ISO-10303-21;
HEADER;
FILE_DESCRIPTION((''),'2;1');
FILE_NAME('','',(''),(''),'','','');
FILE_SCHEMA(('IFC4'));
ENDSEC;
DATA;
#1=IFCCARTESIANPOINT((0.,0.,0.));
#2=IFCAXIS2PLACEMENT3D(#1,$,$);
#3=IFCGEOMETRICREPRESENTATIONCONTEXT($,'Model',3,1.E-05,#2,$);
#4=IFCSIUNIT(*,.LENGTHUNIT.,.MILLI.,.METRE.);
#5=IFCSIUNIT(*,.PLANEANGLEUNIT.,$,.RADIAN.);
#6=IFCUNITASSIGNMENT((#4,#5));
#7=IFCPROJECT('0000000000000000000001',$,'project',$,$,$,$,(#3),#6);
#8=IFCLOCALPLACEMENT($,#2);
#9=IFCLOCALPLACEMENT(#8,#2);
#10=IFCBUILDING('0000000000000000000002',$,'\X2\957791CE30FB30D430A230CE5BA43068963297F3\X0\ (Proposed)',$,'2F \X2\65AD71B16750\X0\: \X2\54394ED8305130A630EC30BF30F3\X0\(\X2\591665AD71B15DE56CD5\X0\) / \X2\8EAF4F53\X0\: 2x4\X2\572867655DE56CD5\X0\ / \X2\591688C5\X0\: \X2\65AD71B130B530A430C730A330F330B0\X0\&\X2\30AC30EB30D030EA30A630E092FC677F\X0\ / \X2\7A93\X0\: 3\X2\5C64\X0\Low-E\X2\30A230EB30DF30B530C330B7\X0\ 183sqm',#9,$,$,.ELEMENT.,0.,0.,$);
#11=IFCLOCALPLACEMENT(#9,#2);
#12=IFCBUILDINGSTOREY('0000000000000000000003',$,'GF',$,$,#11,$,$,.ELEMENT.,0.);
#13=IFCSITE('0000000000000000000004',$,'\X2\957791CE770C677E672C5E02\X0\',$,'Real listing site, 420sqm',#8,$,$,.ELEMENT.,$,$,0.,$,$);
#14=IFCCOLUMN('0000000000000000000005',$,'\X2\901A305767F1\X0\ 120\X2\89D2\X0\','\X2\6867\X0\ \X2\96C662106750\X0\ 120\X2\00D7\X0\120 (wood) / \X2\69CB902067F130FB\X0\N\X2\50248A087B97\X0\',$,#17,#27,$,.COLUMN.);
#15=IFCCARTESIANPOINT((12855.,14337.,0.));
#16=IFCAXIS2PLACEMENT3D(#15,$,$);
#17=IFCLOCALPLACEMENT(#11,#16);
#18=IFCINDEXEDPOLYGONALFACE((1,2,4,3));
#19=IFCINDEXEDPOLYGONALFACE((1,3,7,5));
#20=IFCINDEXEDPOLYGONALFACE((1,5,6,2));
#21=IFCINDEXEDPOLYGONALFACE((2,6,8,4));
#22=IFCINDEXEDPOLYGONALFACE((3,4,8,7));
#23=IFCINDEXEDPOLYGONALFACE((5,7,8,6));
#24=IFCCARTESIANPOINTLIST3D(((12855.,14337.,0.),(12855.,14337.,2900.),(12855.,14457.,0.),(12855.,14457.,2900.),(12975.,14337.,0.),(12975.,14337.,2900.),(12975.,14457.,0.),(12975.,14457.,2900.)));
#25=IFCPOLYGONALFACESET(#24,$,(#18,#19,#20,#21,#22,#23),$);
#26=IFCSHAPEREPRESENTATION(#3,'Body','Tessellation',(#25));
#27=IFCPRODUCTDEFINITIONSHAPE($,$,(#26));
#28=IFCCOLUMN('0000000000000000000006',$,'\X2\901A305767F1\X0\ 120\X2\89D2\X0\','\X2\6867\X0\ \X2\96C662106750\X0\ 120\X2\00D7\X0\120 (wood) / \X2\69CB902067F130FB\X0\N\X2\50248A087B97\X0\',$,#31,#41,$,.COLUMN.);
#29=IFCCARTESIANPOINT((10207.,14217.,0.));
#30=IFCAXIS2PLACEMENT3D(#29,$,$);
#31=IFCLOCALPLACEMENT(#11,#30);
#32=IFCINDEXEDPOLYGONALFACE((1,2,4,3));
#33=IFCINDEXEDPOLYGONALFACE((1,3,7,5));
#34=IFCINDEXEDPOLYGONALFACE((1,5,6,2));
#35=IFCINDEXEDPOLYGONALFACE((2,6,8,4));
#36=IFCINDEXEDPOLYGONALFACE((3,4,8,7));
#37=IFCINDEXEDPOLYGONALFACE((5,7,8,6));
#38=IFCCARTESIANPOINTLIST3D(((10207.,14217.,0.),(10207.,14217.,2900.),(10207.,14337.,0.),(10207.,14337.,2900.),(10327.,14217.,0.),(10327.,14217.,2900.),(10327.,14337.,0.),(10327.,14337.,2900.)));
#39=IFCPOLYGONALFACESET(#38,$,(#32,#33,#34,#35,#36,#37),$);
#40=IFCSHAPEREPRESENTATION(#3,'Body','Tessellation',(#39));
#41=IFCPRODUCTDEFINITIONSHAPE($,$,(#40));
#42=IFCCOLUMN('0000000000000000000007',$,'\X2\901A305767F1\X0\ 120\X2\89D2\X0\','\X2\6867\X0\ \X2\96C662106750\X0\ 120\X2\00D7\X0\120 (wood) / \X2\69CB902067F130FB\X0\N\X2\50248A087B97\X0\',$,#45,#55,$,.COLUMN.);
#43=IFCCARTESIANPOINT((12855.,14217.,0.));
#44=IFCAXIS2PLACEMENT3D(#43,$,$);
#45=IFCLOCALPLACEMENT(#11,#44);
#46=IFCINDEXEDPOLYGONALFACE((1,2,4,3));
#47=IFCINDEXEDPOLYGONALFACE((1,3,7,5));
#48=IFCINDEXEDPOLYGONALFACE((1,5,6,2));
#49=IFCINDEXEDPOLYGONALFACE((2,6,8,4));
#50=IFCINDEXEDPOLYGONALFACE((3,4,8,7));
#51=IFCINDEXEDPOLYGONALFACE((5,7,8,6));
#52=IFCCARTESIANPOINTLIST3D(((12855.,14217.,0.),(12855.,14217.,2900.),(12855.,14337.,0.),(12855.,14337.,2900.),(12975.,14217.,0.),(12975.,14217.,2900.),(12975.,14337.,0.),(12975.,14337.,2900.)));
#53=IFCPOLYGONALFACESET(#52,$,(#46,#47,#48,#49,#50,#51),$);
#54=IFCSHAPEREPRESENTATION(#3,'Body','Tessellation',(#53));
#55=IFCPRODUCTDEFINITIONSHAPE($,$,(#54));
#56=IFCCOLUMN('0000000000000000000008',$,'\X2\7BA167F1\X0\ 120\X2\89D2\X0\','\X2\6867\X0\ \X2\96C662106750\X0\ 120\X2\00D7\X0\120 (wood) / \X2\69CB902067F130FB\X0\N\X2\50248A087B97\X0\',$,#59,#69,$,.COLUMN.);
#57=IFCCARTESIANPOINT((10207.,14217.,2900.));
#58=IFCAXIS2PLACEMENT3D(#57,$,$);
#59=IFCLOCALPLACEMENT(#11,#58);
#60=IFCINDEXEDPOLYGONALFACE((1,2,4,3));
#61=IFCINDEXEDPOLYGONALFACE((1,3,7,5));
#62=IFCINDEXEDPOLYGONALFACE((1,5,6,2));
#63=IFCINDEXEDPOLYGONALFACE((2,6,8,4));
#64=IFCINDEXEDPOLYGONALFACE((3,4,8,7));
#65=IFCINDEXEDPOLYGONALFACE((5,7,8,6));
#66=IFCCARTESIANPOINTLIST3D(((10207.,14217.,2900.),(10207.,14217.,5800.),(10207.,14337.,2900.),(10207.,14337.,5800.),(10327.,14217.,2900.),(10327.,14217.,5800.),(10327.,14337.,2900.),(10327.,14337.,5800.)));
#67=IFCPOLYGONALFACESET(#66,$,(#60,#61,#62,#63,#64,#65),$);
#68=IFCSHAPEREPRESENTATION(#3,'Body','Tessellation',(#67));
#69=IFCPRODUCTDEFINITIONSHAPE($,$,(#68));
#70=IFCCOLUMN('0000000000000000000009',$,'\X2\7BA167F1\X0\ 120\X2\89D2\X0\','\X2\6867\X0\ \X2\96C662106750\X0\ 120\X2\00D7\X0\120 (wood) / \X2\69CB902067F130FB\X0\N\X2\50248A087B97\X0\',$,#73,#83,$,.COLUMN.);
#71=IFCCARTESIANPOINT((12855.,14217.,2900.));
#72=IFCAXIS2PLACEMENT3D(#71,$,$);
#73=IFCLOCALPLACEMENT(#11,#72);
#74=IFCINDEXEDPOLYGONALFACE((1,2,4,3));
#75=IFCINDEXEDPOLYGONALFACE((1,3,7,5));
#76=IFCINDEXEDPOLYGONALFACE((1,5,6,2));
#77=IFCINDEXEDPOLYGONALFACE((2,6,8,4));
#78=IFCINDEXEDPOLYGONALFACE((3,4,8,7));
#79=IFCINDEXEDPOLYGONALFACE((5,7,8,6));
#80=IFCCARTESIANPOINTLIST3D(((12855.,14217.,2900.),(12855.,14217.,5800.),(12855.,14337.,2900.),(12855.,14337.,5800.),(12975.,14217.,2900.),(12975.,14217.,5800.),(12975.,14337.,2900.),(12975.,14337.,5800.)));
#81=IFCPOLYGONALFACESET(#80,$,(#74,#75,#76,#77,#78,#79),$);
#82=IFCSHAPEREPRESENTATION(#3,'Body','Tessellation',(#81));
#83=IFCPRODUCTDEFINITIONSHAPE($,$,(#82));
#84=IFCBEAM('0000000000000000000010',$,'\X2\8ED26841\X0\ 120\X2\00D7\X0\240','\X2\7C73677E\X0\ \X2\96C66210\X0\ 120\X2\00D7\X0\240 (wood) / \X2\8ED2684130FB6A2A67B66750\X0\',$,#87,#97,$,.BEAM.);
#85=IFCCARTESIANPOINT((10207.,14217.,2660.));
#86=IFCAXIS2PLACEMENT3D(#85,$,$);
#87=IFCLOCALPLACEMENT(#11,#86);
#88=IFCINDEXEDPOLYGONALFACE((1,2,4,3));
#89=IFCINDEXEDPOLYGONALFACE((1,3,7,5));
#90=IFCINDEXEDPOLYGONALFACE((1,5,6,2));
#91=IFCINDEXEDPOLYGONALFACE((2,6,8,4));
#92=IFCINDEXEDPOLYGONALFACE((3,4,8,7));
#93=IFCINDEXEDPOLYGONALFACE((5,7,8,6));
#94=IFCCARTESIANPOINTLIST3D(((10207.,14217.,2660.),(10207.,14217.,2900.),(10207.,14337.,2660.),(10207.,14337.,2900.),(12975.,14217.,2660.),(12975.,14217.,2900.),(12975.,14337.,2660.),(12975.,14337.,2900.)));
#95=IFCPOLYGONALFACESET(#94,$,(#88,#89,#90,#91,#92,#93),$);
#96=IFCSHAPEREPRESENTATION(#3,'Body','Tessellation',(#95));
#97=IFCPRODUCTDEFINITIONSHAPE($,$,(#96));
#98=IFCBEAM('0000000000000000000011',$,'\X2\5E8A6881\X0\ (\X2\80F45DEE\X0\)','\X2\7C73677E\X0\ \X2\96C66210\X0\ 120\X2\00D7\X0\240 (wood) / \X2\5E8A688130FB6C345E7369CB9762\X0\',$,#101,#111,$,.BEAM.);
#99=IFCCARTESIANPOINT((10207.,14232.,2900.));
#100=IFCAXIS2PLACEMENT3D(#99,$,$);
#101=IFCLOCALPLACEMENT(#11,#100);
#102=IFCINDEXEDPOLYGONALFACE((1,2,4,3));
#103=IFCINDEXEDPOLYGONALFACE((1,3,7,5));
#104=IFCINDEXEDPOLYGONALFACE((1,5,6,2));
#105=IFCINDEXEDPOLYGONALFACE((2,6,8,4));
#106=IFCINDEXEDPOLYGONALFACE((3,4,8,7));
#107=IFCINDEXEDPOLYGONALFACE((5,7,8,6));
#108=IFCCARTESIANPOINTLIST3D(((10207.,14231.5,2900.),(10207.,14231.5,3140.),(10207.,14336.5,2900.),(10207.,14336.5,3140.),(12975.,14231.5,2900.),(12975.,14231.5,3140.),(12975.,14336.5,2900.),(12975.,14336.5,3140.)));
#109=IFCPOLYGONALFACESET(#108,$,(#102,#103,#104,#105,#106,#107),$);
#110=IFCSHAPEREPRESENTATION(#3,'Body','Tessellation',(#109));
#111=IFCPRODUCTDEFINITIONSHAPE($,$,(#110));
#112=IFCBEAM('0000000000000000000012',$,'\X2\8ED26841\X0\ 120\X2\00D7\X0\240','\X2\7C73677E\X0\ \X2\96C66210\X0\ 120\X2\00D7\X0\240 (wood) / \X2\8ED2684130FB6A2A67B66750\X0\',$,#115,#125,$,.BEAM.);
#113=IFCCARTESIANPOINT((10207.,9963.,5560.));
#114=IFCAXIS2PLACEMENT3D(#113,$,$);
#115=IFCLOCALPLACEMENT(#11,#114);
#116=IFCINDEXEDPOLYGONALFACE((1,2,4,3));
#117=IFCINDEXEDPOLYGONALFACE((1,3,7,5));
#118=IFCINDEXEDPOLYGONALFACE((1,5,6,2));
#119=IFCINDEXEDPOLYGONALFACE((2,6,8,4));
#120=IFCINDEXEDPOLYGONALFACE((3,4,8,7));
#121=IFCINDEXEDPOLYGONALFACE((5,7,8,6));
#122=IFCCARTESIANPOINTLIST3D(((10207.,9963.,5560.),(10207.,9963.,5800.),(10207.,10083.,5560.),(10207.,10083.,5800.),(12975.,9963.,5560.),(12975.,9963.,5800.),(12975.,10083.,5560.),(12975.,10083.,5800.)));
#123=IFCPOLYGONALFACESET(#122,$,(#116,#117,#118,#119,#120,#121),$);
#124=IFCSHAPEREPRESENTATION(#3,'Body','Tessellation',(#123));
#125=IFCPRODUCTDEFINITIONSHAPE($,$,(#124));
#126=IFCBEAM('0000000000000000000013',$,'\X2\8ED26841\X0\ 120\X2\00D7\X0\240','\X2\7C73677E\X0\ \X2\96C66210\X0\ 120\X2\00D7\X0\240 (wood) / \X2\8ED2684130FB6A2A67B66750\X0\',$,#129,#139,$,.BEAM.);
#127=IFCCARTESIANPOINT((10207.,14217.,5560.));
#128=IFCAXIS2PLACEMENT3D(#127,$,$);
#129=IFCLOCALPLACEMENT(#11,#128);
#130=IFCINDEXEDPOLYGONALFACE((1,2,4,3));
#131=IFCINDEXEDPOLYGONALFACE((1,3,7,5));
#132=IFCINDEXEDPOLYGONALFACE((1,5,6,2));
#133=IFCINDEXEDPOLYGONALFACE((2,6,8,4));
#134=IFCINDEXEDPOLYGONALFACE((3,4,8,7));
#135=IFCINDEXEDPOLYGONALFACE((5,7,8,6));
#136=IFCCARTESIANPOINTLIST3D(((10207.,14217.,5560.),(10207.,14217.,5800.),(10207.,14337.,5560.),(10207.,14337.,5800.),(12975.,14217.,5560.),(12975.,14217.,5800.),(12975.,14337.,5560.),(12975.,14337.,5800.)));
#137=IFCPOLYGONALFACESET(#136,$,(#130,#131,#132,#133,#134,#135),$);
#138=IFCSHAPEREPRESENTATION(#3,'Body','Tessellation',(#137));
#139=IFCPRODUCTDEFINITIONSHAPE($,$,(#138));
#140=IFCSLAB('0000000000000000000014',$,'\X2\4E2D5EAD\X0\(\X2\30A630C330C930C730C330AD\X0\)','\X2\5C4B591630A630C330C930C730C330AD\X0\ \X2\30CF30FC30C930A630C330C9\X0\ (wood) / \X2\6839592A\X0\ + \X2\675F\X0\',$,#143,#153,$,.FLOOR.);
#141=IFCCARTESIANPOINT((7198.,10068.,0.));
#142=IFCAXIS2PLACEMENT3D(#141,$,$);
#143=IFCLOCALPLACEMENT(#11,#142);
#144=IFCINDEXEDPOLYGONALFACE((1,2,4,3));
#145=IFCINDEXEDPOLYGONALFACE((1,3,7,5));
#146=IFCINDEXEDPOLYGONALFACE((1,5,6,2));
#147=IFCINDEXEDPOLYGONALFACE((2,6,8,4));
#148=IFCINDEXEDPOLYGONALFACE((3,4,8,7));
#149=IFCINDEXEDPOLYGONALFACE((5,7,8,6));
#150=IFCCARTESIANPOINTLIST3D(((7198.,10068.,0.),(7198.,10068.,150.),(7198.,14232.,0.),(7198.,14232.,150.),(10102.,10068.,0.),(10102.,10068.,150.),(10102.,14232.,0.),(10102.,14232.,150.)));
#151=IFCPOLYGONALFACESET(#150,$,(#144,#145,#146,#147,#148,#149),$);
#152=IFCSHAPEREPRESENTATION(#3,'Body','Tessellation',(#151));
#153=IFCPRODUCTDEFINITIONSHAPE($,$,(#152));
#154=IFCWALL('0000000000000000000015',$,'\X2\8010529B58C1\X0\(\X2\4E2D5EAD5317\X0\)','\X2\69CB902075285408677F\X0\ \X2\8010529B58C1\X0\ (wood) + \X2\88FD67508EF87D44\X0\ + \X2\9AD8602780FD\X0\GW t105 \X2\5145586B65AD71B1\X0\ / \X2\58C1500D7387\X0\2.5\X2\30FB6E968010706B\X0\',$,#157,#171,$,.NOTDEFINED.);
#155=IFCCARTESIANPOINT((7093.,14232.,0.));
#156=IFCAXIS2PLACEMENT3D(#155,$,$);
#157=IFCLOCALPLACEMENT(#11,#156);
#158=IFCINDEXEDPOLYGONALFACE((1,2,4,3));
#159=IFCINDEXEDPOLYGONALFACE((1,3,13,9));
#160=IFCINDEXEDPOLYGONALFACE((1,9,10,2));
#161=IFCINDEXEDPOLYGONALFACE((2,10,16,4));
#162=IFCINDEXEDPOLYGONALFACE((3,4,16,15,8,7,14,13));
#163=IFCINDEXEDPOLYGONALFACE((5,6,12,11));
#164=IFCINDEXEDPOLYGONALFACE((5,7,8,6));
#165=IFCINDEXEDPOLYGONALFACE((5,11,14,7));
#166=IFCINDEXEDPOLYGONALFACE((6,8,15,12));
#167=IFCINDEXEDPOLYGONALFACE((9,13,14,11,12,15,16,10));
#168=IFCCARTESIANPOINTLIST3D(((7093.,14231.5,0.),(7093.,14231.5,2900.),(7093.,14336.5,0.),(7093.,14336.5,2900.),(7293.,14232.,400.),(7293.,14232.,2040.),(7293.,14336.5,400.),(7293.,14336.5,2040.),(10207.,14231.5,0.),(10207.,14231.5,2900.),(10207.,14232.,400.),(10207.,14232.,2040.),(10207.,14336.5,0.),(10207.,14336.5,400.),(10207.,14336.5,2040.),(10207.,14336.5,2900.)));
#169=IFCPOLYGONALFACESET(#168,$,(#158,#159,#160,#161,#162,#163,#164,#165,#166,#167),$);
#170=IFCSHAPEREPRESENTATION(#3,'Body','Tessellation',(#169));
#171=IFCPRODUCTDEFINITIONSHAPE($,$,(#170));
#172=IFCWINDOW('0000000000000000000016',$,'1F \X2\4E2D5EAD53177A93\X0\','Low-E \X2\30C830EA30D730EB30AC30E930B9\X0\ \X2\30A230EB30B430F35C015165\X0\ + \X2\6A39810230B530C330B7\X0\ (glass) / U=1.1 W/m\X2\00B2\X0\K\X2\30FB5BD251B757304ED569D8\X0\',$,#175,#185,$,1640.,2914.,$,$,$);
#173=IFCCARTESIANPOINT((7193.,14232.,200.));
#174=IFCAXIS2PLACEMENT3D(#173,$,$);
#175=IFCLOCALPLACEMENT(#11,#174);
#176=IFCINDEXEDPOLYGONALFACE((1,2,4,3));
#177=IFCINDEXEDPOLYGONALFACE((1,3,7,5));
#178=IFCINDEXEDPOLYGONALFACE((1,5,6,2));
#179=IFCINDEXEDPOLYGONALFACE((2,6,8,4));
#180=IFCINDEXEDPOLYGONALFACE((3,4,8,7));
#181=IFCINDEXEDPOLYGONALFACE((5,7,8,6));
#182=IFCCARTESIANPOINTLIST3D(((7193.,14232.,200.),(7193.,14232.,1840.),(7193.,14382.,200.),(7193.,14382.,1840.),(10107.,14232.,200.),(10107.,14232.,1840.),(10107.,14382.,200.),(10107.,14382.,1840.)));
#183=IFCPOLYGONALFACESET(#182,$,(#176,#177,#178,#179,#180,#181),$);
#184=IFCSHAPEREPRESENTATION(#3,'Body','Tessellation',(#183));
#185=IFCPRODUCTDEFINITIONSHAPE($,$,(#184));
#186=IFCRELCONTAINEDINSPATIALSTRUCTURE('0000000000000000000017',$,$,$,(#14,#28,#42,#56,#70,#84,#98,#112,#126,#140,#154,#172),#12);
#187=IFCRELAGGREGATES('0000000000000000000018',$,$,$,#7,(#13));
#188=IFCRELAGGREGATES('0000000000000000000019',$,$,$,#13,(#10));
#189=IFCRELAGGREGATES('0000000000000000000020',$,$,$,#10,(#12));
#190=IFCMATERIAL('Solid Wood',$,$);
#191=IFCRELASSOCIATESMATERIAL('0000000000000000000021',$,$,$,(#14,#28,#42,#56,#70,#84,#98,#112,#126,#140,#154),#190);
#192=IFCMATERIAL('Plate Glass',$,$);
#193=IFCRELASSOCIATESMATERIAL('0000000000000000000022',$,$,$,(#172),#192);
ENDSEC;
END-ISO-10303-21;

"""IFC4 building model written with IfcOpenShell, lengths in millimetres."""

from ifc_helpers import new_model, si_unit, frame, frame_2d, origin, place, context, project, spatial, rectangle, extrude, material, element, fill, save


model = new_model("IFC4")

# Units and contexts
model_context = context("Model", 3, precision=1e-05, world=origin())
ifc_project = project(units=[si_unit("LENGTHUNIT", "METRE", prefix="MILLI"), si_unit("PLANEANGLEUNIT", "RADIAN")], contexts=[model_context])

# Site, building, storey
site_placement = place(None, origin())
site = spatial("IfcSite", under=ifc_project, at=site_placement, Name="長野県松本市", ObjectType="Real listing site, 420sqm", CompositionType="ELEMENT", RefElevation=0.0)
building_placement = place(site_placement, origin())
building = spatial("IfcBuilding", under=site, at=building_placement, Name="長野・ピアノ室と防音 (Proposed)", ObjectType="2F 断熱材: 吹付けウレタン(外断熱工法) / 躯体: 2x4在来工法 / 外装: 断熱サイディング&ガルバリウム鋼板 / 窓: 3層Low-Eアルミサッシ 183sqm", CompositionType="ELEMENT", ElevationOfRefHeight=0.0, ElevationOfTerrain=0.0)
storey_placement = place(building_placement, origin())
storey = spatial("IfcBuildingStorey", under=building, at=storey_placement, Name="GF", CompositionType="ELEMENT", Elevation=0.0)

# Columns
ifc_material_1 = material(Name="Solid Wood")
column_1_placement = place(storey_placement, frame((12855.0, 14337.0, 0.0)))
element("IfcColumn", 1, at=column_1_placement, inside=storey, material=ifc_material_1, Name="通し柱 120角", Description="桧 集成材 120×120 (wood) / 構造柱・N値計算", PredefinedType="COLUMN", context=model_context, shape_type="SweptSolid", body=[
    extrude(rectangle(XDim=120.0, YDim=120.0, at=frame_2d((60.0, 60.0))), frame((12855.0, 14337.0, 0.0)), (0.0, 0.0, 1.0), 2900.0),
])
column_2_placement = place(storey_placement, frame((10207.0, 14217.0, 0.0)))
element("IfcColumn", 2, at=column_2_placement, inside=storey, material=ifc_material_1, Name="通し柱 120角", Description="桧 集成材 120×120 (wood) / 構造柱・N値計算", PredefinedType="COLUMN", context=model_context, shape_type="SweptSolid", body=[
    extrude(rectangle(XDim=120.0, YDim=120.0, at=frame_2d((60.0, 60.0))), frame((10207.0, 14217.0, 0.0)), (0.0, 0.0, 1.0), 2900.0),
])
column_3_placement = place(storey_placement, frame((12855.0, 14217.0, 0.0)))
element("IfcColumn", 3, at=column_3_placement, inside=storey, material=ifc_material_1, Name="通し柱 120角", Description="桧 集成材 120×120 (wood) / 構造柱・N値計算", PredefinedType="COLUMN", context=model_context, shape_type="SweptSolid", body=[
    extrude(rectangle(XDim=120.0, YDim=120.0, at=frame_2d((60.0, 60.0))), frame((12855.0, 14217.0, 0.0)), (0.0, 0.0, 1.0), 2900.0),
])
column_4_placement = place(storey_placement, frame((10207.0, 14217.0, 2900.0)))
element("IfcColumn", 4, at=column_4_placement, inside=storey, material=ifc_material_1, Name="管柱 120角", Description="桧 集成材 120×120 (wood) / 構造柱・N値計算", PredefinedType="COLUMN", context=model_context, shape_type="SweptSolid", body=[
    extrude(rectangle(XDim=120.0, YDim=120.0, at=frame_2d((60.0, 60.0))), frame((10207.0, 14217.0, 2900.0)), (0.0, 0.0, 1.0), 2900.0),
])
column_5_placement = place(storey_placement, frame((12855.0, 14217.0, 2900.0)))
element("IfcColumn", 5, at=column_5_placement, inside=storey, material=ifc_material_1, Name="管柱 120角", Description="桧 集成材 120×120 (wood) / 構造柱・N値計算", PredefinedType="COLUMN", context=model_context, shape_type="SweptSolid", body=[
    extrude(rectangle(XDim=120.0, YDim=120.0, at=frame_2d((60.0, 60.0))), frame((12855.0, 14217.0, 2900.0)), (0.0, 0.0, 1.0), 2900.0),
])

# Beams
beam_1_placement = place(storey_placement, frame((10207.0, 14217.0, 2660.0)))
element("IfcBeam", 6, at=beam_1_placement, inside=storey, material=ifc_material_1, Name="軒桁 120×240", Description="米松 集成 120×240 (wood) / 軒桁・横架材", PredefinedType="BEAM", context=model_context, shape_type="SweptSolid", body=[
    extrude(rectangle(XDim=2768.0, YDim=120.0, at=frame_2d((1384.0, 60.0))), frame((10207.0, 14217.0, 2660.0)), (0.0, 0.0, 1.0), 240.0),
])
beam_2_placement = place(storey_placement, frame((10207.0, 14232.0, 2900.0)))
element("IfcBeam", 7, at=beam_2_placement, inside=storey, material=ifc_material_1, Name="床梁 (胴差)", Description="米松 集成 120×240 (wood) / 床梁・水平構面", PredefinedType="BEAM", context=model_context, shape_type="SweptSolid", body=[
    extrude(rectangle(XDim=2768.0, YDim=105.0, at=frame_2d((1384.0, 52.0))), frame((10207.0, 14232.0, 2900.0)), (0.0, 0.0, 1.0), 240.0),
])
beam_3_placement = place(storey_placement, frame((10207.0, 9963.0, 5560.0)))
element("IfcBeam", 8, at=beam_3_placement, inside=storey, material=ifc_material_1, Name="軒桁 120×240", Description="米松 集成 120×240 (wood) / 軒桁・横架材", PredefinedType="BEAM", context=model_context, shape_type="SweptSolid", body=[
    extrude(rectangle(XDim=2768.0, YDim=120.0, at=frame_2d((1384.0, 60.0))), frame((10207.0, 9963.0, 5560.0)), (0.0, 0.0, 1.0), 240.0),
])
beam_4_placement = place(storey_placement, frame((10207.0, 14217.0, 5560.0)))
element("IfcBeam", 9, at=beam_4_placement, inside=storey, material=ifc_material_1, Name="軒桁 120×240", Description="米松 集成 120×240 (wood) / 軒桁・横架材", PredefinedType="BEAM", context=model_context, shape_type="SweptSolid", body=[
    extrude(rectangle(XDim=2768.0, YDim=120.0, at=frame_2d((1384.0, 60.0))), frame((10207.0, 14217.0, 5560.0)), (0.0, 0.0, 1.0), 240.0),
])

# Slab
slab_placement = place(storey_placement, frame((7198.0, 10068.0, 0.0)))
element("IfcSlab", 10, at=slab_placement, inside=storey, material=ifc_material_1, Name="中庭(ウッドデッキ)", Description="屋外ウッドデッキ ハードウッド (wood) / 根太 + 束", PredefinedType="FLOOR", context=model_context, shape_type="SweptSolid", body=[
    extrude(rectangle(XDim=2904.0, YDim=4164.0, at=frame_2d((1452.0, 2082.0))), frame((7198.0, 10068.0, 0.0)), (0.0, 0.0, 1.0), 150.0),
])

# Wall, opening, window
wall_1_placement = place(storey_placement, frame((7093.0, 14232.0, 0.0)))
wall_1 = element("IfcWall", 11, at=wall_1_placement, inside=storey, material=ifc_material_1, Name="耐力壁(中庭北)", Description="構造用合板 耐力壁 (wood) + 製材軸組 + 高性能GW t105 充填断熱 / 壁倍率2.5・準耐火", PredefinedType="NOTDEFINED", context=model_context, shape_type="SweptSolid", body=[
    extrude(rectangle(XDim=3114.0, YDim=105.0, at=frame_2d((1557.0, 52.0))), frame((7093.0, 14232.0, 0.0)), (0.0, 0.0, 1.0), 2900.0),
])
opening_1_placement = place(storey_placement, frame((7193.0, 14232.0, 200.0)))
opening_1 = element("IfcOpeningElement", 12, at=opening_1_placement, cuts=wall_1, PredefinedType="NOTDEFINED", context=model_context, shape_type="SweptSolid", body=[
    extrude(rectangle(XDim=2914.0, YDim=150.0, at=frame_2d((1457.0, 75.0))), frame((7193.0, 14232.0, 200.0)), (0.0, 0.0, 1.0), 1640.0),
])
ifc_material_2 = material(Name="Plate Glass")
window_1_placement = place(storey_placement, frame((7193.0, 14232.0, 200.0)))
window_1 = element("IfcWindow", 13, at=window_1_placement, inside=storey, material=ifc_material_2, Name="1F 中庭北窓", Description="Low-E トリプルガラス アルゴン封入 + 樹脂サッシ (glass) / U=1.1 W/m²K・寒冷地仕様", OverallHeight=1640.0, OverallWidth=2914.0, context=model_context, shape_type="SweptSolid", body=[
    extrude(rectangle(XDim=2914.0, YDim=150.0, at=frame_2d((1457.0, 75.0))), frame((7193.0, 14232.0, 200.0)), (0.0, 0.0, 1.0), 1640.0),
])
fill(opening_1, window_1)

save(model, "model.ifc")
